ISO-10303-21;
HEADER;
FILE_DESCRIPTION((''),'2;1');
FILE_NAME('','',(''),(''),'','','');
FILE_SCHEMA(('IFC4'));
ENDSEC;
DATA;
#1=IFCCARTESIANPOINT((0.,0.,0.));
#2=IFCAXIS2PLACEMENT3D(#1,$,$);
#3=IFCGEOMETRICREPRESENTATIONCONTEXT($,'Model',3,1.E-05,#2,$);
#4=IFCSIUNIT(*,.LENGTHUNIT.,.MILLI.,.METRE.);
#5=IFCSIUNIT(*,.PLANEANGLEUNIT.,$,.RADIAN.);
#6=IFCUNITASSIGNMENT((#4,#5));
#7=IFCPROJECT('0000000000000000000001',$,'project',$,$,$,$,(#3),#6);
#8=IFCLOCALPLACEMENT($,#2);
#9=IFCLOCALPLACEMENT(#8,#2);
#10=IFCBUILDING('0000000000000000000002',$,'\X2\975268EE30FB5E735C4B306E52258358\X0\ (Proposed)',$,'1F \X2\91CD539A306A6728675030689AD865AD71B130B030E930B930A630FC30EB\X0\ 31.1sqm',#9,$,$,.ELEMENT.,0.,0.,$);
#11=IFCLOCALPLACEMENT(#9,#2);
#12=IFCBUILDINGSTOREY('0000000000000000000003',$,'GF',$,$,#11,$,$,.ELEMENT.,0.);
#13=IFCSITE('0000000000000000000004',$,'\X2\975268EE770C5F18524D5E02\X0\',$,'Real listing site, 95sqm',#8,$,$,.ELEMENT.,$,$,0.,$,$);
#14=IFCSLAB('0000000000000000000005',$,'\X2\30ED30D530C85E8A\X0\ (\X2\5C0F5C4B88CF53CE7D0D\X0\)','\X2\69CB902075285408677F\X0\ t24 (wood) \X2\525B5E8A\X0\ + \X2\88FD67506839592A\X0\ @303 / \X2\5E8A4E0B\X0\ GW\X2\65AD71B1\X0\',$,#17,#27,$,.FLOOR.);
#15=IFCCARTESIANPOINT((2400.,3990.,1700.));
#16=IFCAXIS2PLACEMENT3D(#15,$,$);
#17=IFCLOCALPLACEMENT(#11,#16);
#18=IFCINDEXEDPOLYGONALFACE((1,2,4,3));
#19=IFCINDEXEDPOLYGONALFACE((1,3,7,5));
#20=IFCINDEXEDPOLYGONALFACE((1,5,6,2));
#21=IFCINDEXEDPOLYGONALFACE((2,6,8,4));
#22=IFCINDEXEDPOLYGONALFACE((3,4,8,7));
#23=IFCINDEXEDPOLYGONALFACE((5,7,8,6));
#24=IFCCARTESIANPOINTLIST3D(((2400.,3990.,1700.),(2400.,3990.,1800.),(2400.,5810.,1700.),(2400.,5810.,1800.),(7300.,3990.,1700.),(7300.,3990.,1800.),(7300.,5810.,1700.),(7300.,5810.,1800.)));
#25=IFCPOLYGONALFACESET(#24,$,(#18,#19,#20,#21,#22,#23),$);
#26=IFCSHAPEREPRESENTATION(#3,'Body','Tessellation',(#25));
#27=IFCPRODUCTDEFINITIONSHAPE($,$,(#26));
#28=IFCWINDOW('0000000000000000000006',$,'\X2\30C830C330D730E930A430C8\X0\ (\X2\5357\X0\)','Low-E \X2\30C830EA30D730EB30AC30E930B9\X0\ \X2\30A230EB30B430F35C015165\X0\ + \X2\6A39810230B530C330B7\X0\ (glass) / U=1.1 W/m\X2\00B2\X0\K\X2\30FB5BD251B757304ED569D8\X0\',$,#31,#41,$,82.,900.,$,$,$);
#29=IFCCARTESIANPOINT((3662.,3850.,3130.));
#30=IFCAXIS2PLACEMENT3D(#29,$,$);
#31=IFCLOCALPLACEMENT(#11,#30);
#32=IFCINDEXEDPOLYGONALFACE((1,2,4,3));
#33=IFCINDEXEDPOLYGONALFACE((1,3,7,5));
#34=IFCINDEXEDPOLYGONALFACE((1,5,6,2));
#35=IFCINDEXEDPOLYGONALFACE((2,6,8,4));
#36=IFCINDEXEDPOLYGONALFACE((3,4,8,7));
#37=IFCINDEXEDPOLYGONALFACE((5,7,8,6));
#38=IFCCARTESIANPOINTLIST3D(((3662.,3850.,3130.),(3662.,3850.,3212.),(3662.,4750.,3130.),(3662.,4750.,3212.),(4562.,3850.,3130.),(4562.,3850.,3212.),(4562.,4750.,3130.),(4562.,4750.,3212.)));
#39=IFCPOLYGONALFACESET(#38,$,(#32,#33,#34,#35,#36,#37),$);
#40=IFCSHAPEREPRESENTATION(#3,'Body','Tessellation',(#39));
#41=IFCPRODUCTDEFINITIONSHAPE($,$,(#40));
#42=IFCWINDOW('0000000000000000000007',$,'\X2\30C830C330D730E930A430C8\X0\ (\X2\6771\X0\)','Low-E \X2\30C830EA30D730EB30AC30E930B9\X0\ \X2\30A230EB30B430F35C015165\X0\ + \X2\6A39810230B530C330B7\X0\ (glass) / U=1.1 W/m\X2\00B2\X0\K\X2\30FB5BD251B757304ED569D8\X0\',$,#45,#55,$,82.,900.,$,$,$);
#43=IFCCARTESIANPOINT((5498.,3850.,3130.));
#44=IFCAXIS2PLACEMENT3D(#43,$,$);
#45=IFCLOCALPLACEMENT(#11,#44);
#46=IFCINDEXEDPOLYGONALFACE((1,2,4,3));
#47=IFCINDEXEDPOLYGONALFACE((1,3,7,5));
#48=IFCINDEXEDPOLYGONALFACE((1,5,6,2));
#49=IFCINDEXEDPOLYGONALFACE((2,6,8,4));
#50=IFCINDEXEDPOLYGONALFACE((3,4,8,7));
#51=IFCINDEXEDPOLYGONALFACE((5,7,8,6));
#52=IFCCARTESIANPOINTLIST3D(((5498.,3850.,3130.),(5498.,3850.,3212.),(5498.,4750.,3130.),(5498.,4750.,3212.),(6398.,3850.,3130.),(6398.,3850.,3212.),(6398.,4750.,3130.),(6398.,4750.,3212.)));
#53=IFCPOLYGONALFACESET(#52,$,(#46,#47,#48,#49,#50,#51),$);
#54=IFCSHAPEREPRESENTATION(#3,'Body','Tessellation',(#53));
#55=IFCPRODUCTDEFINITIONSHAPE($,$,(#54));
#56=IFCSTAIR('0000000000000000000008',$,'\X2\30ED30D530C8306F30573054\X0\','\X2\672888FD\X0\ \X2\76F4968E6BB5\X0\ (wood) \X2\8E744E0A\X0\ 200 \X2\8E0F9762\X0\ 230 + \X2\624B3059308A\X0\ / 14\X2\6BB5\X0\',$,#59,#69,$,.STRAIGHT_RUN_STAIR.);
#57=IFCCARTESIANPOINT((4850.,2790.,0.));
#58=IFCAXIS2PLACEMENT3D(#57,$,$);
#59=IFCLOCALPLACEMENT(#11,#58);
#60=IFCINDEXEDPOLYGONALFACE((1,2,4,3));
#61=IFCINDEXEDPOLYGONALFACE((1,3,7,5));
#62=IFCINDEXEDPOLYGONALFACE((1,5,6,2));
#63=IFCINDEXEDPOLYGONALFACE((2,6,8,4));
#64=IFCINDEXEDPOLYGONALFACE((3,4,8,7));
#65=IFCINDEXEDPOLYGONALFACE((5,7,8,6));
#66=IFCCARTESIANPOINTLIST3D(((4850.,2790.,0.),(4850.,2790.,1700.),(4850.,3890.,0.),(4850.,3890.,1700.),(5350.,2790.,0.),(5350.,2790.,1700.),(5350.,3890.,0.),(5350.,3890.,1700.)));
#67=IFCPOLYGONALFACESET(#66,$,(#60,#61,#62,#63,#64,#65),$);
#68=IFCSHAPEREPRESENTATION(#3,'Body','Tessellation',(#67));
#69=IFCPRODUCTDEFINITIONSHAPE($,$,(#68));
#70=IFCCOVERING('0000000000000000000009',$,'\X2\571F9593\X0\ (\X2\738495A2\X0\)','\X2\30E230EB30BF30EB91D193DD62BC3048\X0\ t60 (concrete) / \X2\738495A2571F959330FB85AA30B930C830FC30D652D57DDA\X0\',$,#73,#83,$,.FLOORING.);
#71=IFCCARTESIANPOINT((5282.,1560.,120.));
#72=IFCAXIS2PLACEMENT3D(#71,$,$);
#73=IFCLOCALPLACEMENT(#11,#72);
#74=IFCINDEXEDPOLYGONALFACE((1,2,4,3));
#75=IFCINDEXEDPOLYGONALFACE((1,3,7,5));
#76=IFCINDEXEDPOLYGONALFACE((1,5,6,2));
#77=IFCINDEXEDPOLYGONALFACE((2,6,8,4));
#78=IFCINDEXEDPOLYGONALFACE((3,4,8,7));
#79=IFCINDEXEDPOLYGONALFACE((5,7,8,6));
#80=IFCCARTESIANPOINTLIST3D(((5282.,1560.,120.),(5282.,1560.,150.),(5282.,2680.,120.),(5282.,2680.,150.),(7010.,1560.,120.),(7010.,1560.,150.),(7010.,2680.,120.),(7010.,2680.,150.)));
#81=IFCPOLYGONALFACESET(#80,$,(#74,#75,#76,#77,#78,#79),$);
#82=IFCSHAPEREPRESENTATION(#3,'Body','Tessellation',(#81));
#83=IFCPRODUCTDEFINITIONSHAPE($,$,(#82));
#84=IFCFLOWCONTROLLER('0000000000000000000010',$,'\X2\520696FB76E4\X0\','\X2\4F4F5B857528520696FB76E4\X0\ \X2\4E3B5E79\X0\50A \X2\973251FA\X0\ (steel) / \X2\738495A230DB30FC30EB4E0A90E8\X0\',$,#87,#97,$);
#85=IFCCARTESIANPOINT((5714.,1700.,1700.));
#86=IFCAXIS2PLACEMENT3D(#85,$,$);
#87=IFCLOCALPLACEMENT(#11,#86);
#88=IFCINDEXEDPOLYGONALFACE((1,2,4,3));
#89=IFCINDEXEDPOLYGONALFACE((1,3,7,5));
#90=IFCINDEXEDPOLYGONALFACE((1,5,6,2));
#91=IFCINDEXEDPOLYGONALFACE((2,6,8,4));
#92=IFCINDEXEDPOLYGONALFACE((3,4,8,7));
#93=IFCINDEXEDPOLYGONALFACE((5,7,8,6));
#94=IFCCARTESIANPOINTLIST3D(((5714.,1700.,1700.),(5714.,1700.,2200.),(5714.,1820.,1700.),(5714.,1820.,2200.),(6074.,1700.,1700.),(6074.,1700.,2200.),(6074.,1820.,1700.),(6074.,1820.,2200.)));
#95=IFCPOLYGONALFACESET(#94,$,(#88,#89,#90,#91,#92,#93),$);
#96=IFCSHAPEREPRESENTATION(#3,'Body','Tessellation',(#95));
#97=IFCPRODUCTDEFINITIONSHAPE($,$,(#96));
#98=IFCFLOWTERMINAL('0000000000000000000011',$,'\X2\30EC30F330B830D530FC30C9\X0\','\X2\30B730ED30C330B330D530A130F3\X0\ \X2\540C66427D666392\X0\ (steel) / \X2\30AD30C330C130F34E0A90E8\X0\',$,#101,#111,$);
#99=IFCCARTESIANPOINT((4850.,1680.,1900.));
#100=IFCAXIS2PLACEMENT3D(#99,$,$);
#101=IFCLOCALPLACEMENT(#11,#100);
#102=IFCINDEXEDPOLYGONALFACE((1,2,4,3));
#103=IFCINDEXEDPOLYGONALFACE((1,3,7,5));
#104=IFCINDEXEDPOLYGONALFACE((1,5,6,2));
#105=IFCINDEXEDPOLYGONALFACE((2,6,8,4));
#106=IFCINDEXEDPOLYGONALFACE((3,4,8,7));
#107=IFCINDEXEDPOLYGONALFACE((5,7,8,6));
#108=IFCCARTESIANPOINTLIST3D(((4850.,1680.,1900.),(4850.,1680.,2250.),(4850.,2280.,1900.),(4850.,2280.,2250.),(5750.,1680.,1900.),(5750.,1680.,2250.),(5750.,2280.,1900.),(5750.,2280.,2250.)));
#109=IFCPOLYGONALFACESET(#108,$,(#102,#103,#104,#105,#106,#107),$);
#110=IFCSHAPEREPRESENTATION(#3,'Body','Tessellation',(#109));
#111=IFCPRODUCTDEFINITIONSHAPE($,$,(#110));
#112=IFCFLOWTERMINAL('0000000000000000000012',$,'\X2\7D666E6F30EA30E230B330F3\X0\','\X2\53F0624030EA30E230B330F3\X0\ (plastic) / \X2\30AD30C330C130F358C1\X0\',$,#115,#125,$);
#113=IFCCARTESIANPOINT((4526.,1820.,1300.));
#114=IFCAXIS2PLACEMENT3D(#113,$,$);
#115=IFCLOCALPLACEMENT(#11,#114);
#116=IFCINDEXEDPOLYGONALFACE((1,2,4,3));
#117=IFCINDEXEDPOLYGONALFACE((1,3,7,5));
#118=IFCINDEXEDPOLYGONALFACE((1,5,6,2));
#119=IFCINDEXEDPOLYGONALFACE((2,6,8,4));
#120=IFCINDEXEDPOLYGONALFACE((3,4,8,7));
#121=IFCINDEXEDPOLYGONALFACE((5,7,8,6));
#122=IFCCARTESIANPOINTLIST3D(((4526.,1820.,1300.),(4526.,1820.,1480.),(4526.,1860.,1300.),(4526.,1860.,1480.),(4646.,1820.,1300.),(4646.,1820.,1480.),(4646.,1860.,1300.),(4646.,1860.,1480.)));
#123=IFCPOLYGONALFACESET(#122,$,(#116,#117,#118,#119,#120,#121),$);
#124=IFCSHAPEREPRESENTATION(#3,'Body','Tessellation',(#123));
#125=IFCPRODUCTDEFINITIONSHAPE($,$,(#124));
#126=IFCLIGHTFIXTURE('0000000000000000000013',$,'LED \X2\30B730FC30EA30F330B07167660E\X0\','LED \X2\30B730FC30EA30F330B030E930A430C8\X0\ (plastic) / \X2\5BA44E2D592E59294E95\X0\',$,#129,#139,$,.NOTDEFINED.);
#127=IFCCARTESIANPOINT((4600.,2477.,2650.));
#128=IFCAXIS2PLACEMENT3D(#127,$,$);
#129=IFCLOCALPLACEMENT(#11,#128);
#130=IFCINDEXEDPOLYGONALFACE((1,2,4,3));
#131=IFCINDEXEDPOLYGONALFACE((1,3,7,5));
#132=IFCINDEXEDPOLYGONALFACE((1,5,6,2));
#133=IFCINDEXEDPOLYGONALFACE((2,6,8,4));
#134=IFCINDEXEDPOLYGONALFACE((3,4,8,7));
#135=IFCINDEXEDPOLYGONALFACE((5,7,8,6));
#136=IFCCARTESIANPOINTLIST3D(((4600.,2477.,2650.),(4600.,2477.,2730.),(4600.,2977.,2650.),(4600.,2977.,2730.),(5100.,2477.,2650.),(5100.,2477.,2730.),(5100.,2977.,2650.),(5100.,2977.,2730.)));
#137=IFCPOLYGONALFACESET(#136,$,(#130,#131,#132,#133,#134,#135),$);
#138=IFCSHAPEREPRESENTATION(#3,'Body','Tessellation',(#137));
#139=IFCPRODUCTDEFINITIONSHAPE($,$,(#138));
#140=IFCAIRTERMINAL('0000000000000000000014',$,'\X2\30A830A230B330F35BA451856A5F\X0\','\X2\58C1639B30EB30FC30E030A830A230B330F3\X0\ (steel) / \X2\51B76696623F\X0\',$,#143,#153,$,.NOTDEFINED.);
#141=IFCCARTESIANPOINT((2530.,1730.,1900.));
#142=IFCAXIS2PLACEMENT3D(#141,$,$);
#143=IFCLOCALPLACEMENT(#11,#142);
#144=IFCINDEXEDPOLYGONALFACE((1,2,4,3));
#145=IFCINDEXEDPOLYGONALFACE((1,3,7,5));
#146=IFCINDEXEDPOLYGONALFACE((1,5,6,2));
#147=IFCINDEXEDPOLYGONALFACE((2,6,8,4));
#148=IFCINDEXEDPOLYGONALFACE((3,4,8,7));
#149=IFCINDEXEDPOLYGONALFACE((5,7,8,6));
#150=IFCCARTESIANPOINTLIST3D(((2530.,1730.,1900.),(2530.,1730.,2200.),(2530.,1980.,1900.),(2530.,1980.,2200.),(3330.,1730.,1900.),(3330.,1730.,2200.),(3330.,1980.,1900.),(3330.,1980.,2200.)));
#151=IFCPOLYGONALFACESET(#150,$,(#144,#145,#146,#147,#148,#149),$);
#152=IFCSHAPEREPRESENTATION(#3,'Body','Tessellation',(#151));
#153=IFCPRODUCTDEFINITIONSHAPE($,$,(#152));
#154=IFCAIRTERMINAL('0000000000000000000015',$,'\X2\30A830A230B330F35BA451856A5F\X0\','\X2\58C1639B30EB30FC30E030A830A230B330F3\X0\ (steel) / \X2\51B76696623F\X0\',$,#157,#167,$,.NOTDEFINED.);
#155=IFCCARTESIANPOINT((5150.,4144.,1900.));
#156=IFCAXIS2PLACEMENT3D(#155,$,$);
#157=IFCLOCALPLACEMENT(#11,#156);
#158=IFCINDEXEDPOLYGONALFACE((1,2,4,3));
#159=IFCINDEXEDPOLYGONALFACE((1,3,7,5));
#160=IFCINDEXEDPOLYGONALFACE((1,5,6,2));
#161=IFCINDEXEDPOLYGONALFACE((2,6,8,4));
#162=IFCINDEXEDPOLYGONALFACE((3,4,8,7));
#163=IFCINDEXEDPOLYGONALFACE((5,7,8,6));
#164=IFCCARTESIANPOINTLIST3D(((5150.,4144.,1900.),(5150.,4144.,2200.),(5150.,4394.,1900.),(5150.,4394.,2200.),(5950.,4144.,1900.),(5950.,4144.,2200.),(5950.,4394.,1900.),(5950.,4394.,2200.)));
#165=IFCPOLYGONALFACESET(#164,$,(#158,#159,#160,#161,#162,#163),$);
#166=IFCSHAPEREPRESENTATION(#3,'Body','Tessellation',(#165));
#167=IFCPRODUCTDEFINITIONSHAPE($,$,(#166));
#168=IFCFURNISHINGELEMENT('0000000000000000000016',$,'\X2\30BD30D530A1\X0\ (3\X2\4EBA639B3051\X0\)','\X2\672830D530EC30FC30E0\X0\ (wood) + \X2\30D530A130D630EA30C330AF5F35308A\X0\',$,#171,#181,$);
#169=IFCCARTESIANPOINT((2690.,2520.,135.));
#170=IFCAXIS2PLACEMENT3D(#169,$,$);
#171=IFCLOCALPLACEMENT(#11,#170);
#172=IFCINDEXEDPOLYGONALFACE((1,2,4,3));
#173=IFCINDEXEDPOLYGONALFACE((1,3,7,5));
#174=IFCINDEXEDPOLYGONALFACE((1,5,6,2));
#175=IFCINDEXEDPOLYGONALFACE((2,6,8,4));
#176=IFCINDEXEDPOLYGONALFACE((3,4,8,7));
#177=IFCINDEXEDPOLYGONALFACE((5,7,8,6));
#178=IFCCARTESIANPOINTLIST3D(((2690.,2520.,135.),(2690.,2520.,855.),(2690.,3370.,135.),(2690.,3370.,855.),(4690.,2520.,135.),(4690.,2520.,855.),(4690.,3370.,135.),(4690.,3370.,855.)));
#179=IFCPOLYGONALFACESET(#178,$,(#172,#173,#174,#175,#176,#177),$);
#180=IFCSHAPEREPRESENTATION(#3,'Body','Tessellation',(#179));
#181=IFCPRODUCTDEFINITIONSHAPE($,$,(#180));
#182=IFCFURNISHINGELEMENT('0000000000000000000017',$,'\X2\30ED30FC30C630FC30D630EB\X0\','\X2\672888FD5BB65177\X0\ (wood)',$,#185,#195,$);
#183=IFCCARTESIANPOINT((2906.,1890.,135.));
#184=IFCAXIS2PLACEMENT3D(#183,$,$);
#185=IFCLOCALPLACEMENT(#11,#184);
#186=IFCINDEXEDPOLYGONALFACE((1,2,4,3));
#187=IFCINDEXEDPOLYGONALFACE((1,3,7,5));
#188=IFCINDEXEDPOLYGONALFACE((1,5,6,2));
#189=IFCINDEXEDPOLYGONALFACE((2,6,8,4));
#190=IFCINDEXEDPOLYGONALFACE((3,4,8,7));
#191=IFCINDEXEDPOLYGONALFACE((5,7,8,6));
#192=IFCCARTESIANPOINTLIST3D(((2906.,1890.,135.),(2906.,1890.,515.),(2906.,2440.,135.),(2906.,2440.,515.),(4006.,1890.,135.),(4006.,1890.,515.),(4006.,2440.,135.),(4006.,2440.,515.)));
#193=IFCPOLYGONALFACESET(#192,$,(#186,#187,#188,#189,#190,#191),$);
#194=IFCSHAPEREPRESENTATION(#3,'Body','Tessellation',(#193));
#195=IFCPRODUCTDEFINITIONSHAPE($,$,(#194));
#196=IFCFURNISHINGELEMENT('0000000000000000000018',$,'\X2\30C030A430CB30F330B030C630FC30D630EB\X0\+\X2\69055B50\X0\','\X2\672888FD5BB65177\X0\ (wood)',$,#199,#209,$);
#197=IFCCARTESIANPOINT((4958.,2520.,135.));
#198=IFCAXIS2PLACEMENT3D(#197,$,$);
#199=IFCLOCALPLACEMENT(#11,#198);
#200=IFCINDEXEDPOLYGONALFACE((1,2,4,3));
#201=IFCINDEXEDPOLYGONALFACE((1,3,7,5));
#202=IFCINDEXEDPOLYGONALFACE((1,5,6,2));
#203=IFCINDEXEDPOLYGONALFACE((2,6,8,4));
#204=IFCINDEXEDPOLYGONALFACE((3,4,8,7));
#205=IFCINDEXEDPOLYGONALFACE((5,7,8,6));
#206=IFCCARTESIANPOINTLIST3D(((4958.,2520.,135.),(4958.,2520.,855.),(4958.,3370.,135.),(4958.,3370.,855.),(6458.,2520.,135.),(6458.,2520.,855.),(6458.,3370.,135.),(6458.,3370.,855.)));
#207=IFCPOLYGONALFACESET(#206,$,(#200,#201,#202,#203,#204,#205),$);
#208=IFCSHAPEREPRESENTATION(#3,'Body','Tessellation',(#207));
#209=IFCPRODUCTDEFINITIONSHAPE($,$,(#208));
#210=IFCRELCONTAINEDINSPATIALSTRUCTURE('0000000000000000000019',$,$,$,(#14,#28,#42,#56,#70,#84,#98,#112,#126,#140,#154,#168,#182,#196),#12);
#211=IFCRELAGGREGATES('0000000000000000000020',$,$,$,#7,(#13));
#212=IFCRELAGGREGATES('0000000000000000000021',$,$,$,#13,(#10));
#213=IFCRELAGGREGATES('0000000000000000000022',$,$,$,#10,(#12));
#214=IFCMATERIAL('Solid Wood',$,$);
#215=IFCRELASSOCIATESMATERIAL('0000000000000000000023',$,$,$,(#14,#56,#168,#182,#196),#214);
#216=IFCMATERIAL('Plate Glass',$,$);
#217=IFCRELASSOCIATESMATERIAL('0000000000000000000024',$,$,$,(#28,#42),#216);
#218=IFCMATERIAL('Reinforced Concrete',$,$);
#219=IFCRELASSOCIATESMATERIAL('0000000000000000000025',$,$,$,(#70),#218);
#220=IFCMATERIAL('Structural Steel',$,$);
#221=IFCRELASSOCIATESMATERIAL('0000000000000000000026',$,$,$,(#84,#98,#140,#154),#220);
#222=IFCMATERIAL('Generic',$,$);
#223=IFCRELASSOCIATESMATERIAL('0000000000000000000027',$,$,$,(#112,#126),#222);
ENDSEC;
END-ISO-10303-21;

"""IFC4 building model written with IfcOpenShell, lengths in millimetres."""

from ifc_helpers import new_model, si_unit, frame, frame_2d, origin, place, context, project, spatial, rectangle, extrude, material, element, save


model = new_model("IFC4")

# Units and contexts
model_context = context("Model", 3, precision=1e-05, world=origin())
ifc_project = project(units=[si_unit("LENGTHUNIT", "METRE", prefix="MILLI"), si_unit("PLANEANGLEUNIT", "RADIAN")], contexts=[model_context])

# Site, building, storey
site_placement = place(None, origin())
site = spatial("IfcSite", under=ifc_project, at=site_placement, Name="青森県弘前市", ObjectType="Real listing site, 95sqm", CompositionType="ELEMENT", RefElevation=0.0)
building_placement = place(site_placement, origin())
building = spatial("IfcBuilding", under=site, at=building_placement, Name="青森・平屋の別荘 (Proposed)", ObjectType="1F 重厚な木材と高断熱グラスウール 31.1sqm", CompositionType="ELEMENT", ElevationOfRefHeight=0.0, ElevationOfTerrain=0.0)
storey_placement = place(building_placement, origin())
storey = spatial("IfcBuildingStorey", under=building, at=storey_placement, Name="GF", CompositionType="ELEMENT", Elevation=0.0)

# Shared definitions
ifc_material_1 = material(Name="Solid Wood")

# Slab
slab_placement = place(storey_placement, frame((2400.0, 3990.0, 1700.0)))
element("IfcSlab", 1, at=slab_placement, inside=storey, material=ifc_material_1, Name="ロフト床 (小屋裏収納)", Description="構造用合板 t24 (wood) 剛床 + 製材根太 @303 / 床下 GW断熱", PredefinedType="FLOOR", context=model_context, shape_type="SweptSolid", body=[
    extrude(rectangle(XDim=4900.0, YDim=1820.0, at=frame_2d((2450.0, 910.0))), frame((2400.0, 3990.0, 1700.0)), (0.0, 0.0, 1.0), 100.0),
])

# Windows
ifc_material_2 = material(Name="Plate Glass")
window_1_placement = place(storey_placement, frame((3662.0, 3850.0, 3130.0)))
element("IfcWindow", 2, at=window_1_placement, inside=storey, material=ifc_material_2, Name="トップライト (南)", Description="Low-E トリプルガラス アルゴン封入 + 樹脂サッシ (glass) / U=1.1 W/m²K・寒冷地仕様", OverallHeight=82.0, OverallWidth=900.0, context=model_context, shape_type="SweptSolid", body=[
    extrude(rectangle(XDim=900.0, YDim=900.0, at=frame_2d((450.0, 450.0))), frame((3662.0, 3850.0, 3130.0)), (0.0, 0.0, 1.0), 82.0),
])
window_2_placement = place(storey_placement, frame((5498.0, 3850.0, 3130.0)))
element("IfcWindow", 3, at=window_2_placement, inside=storey, material=ifc_material_2, Name="トップライト (東)", Description="Low-E トリプルガラス アルゴン封入 + 樹脂サッシ (glass) / U=1.1 W/m²K・寒冷地仕様", OverallHeight=82.0, OverallWidth=900.0, context=model_context, shape_type="SweptSolid", body=[
    extrude(rectangle(XDim=900.0, YDim=900.0, at=frame_2d((450.0, 450.0))), frame((5498.0, 3850.0, 3130.0)), (0.0, 0.0, 1.0), 82.0),
])

# Stair
stair_placement = place(storey_placement, frame((4850.0, 2790.0, 0.0)))
element("IfcStair", 4, at=stair_placement, inside=storey, material=ifc_material_1, Name="ロフトはしご", Description="木製 直階段 (wood) 蹴上 200 踏面 230 + 手すり / 14段", PredefinedType="STRAIGHT_RUN_STAIR", context=model_context, shape_type="SweptSolid", body=[
    extrude(rectangle(XDim=500.0, YDim=1100.0, at=frame_2d((250.0, 550.0))), frame((4850.0, 2790.0, 0.0)), (0.0, 0.0, 1.0), 1700.0),
])

# Covering
ifc_material_3 = material(Name="Reinforced Concrete")
covering_placement = place(storey_placement, frame((5282.0, 1560.0, 120.0)))
element("IfcCovering", 5, at=covering_placement, inside=storey, material=ifc_material_3, Name="土間 (玄関)", Description="モルタル金鏝押え t60 (concrete) / 玄関土間・薪ストーブ動線", PredefinedType="FLOORING", context=model_context, shape_type="SweptSolid", body=[
    extrude(rectangle(XDim=1728.0, YDim=1120.0, at=frame_2d((864.0, 560.0))), frame((5282.0, 1560.0, 120.0)), (0.0, 0.0, 1.0), 30.0),
])

# Flow controller
ifc_material_4 = material(Name="Structural Steel")
flow_controller_placement = place(storey_placement, frame((5714.0, 1700.0, 1700.0)))
element("IfcFlowController", 6, at=flow_controller_placement, inside=storey, material=ifc_material_4, Name="分電盤", Description="住宅用分電盤 主幹50A 露出 (steel) / 玄関ホール上部", context=model_context, shape_type="SweptSolid", body=[
    extrude(rectangle(XDim=360.0, YDim=120.0, at=frame_2d((180.0, 60.0))), frame((5714.0, 1700.0, 1700.0)), (0.0, 0.0, 1.0), 500.0),
])

# Flow terminals
flow_terminal_1_placement = place(storey_placement, frame((4850.0, 1680.0, 1900.0)))
element("IfcFlowTerminal", 7, at=flow_terminal_1_placement, inside=storey, material=ifc_material_4, Name="レンジフード", Description="シロッコファン 同時給排 (steel) / キッチン上部", context=model_context, shape_type="SweptSolid", body=[
    extrude(rectangle(XDim=900.0, YDim=600.0, at=frame_2d((450.0, 300.0))), frame((4850.0, 1680.0, 1900.0)), (0.0, 0.0, 1.0), 350.0),
])
ifc_material_5 = material(Name="Generic")
flow_terminal_2_placement = place(storey_placement, frame((4526.0, 1820.0, 1300.0)))
element("IfcFlowTerminal", 8, at=flow_terminal_2_placement, inside=storey, material=ifc_material_5, Name="給湯リモコン", Description="台所リモコン (plastic) / キッチン壁", context=model_context, shape_type="SweptSolid", body=[
    extrude(rectangle(XDim=120.0, YDim=40.0, at=frame_2d((60.0, 20.0))), frame((4526.0, 1820.0, 1300.0)), (0.0, 0.0, 1.0), 180.0),
])

# Light fixture
light_fixture_placement = place(storey_placement, frame((4600.0, 2477.0, 2650.0)))
element("IfcLightFixture", 9, at=light_fixture_placement, inside=storey, material=ifc_material_5, Name="LED シーリング照明", Description="LED シーリングライト (plastic) / 室中央天井", PredefinedType="NOTDEFINED", context=model_context, shape_type="SweptSolid", body=[
    extrude(rectangle(XDim=500.0, YDim=500.0, at=frame_2d((250.0, 250.0))), frame((4600.0, 2477.0, 2650.0)), (0.0, 0.0, 1.0), 80.0),
])

# Air terminals
air_terminal_1_placement = place(storey_placement, frame((2530.0, 1730.0, 1900.0)))
element("IfcAirTerminal", 10, at=air_terminal_1_placement, inside=storey, material=ifc_material_4, Name="エアコン室内機", Description="壁掛ルームエアコン (steel) / 冷暖房", PredefinedType="NOTDEFINED", context=model_context, shape_type="SweptSolid", body=[
    extrude(rectangle(XDim=800.0, YDim=250.0, at=frame_2d((400.0, 125.0))), frame((2530.0, 1730.0, 1900.0)), (0.0, 0.0, 1.0), 300.0),
])
air_terminal_2_placement = place(storey_placement, frame((5150.0, 4144.0, 1900.0)))
element("IfcAirTerminal", 11, at=air_terminal_2_placement, inside=storey, material=ifc_material_4, Name="エアコン室内機", Description="壁掛ルームエアコン (steel) / 冷暖房", PredefinedType="NOTDEFINED", context=model_context, shape_type="SweptSolid", body=[
    extrude(rectangle(XDim=800.0, YDim=250.0, at=frame_2d((400.0, 125.0))), frame((5150.0, 4144.0, 1900.0)), (0.0, 0.0, 1.0), 300.0),
])

# Furnishing elements
furnishing_1_placement = place(storey_placement, frame((2690.0, 2520.0, 135.0)))
element("IfcFurnishingElement", 12, at=furnishing_1_placement, inside=storey, material=ifc_material_1, Name="ソファ (3人掛け)", Description="木フレーム (wood) + ファブリック張り", context=model_context, shape_type="SweptSolid", body=[
    extrude(rectangle(XDim=2000.0, YDim=850.0, at=frame_2d((1000.0, 425.0))), frame((2690.0, 2520.0, 135.0)), (0.0, 0.0, 1.0), 720.0),
])
furnishing_2_placement = place(storey_placement, frame((2906.0, 1890.0, 135.0)))
element("IfcFurnishingElement", 13, at=furnishing_2_placement, inside=storey, material=ifc_material_1, Name="ローテーブル", Description="木製家具 (wood)", context=model_context, shape_type="SweptSolid", body=[
    extrude(rectangle(XDim=1100.0, YDim=550.0, at=frame_2d((550.0, 275.0))), frame((2906.0, 1890.0, 135.0)), (0.0, 0.0, 1.0), 380.0),
])
furnishing_3_placement = place(storey_placement, frame((4958.0, 2520.0, 135.0)))
element("IfcFurnishingElement", 14, at=furnishing_3_placement, inside=storey, material=ifc_material_1, Name="ダイニングテーブル+椅子", Description="木製家具 (wood)", context=model_context, shape_type="SweptSolid", body=[
    extrude(rectangle(XDim=1500.0, YDim=850.0, at=frame_2d((750.0, 425.0))), frame((4958.0, 2520.0, 135.0)), (0.0, 0.0, 1.0), 720.0),
])

save(model, "model.ifc")
